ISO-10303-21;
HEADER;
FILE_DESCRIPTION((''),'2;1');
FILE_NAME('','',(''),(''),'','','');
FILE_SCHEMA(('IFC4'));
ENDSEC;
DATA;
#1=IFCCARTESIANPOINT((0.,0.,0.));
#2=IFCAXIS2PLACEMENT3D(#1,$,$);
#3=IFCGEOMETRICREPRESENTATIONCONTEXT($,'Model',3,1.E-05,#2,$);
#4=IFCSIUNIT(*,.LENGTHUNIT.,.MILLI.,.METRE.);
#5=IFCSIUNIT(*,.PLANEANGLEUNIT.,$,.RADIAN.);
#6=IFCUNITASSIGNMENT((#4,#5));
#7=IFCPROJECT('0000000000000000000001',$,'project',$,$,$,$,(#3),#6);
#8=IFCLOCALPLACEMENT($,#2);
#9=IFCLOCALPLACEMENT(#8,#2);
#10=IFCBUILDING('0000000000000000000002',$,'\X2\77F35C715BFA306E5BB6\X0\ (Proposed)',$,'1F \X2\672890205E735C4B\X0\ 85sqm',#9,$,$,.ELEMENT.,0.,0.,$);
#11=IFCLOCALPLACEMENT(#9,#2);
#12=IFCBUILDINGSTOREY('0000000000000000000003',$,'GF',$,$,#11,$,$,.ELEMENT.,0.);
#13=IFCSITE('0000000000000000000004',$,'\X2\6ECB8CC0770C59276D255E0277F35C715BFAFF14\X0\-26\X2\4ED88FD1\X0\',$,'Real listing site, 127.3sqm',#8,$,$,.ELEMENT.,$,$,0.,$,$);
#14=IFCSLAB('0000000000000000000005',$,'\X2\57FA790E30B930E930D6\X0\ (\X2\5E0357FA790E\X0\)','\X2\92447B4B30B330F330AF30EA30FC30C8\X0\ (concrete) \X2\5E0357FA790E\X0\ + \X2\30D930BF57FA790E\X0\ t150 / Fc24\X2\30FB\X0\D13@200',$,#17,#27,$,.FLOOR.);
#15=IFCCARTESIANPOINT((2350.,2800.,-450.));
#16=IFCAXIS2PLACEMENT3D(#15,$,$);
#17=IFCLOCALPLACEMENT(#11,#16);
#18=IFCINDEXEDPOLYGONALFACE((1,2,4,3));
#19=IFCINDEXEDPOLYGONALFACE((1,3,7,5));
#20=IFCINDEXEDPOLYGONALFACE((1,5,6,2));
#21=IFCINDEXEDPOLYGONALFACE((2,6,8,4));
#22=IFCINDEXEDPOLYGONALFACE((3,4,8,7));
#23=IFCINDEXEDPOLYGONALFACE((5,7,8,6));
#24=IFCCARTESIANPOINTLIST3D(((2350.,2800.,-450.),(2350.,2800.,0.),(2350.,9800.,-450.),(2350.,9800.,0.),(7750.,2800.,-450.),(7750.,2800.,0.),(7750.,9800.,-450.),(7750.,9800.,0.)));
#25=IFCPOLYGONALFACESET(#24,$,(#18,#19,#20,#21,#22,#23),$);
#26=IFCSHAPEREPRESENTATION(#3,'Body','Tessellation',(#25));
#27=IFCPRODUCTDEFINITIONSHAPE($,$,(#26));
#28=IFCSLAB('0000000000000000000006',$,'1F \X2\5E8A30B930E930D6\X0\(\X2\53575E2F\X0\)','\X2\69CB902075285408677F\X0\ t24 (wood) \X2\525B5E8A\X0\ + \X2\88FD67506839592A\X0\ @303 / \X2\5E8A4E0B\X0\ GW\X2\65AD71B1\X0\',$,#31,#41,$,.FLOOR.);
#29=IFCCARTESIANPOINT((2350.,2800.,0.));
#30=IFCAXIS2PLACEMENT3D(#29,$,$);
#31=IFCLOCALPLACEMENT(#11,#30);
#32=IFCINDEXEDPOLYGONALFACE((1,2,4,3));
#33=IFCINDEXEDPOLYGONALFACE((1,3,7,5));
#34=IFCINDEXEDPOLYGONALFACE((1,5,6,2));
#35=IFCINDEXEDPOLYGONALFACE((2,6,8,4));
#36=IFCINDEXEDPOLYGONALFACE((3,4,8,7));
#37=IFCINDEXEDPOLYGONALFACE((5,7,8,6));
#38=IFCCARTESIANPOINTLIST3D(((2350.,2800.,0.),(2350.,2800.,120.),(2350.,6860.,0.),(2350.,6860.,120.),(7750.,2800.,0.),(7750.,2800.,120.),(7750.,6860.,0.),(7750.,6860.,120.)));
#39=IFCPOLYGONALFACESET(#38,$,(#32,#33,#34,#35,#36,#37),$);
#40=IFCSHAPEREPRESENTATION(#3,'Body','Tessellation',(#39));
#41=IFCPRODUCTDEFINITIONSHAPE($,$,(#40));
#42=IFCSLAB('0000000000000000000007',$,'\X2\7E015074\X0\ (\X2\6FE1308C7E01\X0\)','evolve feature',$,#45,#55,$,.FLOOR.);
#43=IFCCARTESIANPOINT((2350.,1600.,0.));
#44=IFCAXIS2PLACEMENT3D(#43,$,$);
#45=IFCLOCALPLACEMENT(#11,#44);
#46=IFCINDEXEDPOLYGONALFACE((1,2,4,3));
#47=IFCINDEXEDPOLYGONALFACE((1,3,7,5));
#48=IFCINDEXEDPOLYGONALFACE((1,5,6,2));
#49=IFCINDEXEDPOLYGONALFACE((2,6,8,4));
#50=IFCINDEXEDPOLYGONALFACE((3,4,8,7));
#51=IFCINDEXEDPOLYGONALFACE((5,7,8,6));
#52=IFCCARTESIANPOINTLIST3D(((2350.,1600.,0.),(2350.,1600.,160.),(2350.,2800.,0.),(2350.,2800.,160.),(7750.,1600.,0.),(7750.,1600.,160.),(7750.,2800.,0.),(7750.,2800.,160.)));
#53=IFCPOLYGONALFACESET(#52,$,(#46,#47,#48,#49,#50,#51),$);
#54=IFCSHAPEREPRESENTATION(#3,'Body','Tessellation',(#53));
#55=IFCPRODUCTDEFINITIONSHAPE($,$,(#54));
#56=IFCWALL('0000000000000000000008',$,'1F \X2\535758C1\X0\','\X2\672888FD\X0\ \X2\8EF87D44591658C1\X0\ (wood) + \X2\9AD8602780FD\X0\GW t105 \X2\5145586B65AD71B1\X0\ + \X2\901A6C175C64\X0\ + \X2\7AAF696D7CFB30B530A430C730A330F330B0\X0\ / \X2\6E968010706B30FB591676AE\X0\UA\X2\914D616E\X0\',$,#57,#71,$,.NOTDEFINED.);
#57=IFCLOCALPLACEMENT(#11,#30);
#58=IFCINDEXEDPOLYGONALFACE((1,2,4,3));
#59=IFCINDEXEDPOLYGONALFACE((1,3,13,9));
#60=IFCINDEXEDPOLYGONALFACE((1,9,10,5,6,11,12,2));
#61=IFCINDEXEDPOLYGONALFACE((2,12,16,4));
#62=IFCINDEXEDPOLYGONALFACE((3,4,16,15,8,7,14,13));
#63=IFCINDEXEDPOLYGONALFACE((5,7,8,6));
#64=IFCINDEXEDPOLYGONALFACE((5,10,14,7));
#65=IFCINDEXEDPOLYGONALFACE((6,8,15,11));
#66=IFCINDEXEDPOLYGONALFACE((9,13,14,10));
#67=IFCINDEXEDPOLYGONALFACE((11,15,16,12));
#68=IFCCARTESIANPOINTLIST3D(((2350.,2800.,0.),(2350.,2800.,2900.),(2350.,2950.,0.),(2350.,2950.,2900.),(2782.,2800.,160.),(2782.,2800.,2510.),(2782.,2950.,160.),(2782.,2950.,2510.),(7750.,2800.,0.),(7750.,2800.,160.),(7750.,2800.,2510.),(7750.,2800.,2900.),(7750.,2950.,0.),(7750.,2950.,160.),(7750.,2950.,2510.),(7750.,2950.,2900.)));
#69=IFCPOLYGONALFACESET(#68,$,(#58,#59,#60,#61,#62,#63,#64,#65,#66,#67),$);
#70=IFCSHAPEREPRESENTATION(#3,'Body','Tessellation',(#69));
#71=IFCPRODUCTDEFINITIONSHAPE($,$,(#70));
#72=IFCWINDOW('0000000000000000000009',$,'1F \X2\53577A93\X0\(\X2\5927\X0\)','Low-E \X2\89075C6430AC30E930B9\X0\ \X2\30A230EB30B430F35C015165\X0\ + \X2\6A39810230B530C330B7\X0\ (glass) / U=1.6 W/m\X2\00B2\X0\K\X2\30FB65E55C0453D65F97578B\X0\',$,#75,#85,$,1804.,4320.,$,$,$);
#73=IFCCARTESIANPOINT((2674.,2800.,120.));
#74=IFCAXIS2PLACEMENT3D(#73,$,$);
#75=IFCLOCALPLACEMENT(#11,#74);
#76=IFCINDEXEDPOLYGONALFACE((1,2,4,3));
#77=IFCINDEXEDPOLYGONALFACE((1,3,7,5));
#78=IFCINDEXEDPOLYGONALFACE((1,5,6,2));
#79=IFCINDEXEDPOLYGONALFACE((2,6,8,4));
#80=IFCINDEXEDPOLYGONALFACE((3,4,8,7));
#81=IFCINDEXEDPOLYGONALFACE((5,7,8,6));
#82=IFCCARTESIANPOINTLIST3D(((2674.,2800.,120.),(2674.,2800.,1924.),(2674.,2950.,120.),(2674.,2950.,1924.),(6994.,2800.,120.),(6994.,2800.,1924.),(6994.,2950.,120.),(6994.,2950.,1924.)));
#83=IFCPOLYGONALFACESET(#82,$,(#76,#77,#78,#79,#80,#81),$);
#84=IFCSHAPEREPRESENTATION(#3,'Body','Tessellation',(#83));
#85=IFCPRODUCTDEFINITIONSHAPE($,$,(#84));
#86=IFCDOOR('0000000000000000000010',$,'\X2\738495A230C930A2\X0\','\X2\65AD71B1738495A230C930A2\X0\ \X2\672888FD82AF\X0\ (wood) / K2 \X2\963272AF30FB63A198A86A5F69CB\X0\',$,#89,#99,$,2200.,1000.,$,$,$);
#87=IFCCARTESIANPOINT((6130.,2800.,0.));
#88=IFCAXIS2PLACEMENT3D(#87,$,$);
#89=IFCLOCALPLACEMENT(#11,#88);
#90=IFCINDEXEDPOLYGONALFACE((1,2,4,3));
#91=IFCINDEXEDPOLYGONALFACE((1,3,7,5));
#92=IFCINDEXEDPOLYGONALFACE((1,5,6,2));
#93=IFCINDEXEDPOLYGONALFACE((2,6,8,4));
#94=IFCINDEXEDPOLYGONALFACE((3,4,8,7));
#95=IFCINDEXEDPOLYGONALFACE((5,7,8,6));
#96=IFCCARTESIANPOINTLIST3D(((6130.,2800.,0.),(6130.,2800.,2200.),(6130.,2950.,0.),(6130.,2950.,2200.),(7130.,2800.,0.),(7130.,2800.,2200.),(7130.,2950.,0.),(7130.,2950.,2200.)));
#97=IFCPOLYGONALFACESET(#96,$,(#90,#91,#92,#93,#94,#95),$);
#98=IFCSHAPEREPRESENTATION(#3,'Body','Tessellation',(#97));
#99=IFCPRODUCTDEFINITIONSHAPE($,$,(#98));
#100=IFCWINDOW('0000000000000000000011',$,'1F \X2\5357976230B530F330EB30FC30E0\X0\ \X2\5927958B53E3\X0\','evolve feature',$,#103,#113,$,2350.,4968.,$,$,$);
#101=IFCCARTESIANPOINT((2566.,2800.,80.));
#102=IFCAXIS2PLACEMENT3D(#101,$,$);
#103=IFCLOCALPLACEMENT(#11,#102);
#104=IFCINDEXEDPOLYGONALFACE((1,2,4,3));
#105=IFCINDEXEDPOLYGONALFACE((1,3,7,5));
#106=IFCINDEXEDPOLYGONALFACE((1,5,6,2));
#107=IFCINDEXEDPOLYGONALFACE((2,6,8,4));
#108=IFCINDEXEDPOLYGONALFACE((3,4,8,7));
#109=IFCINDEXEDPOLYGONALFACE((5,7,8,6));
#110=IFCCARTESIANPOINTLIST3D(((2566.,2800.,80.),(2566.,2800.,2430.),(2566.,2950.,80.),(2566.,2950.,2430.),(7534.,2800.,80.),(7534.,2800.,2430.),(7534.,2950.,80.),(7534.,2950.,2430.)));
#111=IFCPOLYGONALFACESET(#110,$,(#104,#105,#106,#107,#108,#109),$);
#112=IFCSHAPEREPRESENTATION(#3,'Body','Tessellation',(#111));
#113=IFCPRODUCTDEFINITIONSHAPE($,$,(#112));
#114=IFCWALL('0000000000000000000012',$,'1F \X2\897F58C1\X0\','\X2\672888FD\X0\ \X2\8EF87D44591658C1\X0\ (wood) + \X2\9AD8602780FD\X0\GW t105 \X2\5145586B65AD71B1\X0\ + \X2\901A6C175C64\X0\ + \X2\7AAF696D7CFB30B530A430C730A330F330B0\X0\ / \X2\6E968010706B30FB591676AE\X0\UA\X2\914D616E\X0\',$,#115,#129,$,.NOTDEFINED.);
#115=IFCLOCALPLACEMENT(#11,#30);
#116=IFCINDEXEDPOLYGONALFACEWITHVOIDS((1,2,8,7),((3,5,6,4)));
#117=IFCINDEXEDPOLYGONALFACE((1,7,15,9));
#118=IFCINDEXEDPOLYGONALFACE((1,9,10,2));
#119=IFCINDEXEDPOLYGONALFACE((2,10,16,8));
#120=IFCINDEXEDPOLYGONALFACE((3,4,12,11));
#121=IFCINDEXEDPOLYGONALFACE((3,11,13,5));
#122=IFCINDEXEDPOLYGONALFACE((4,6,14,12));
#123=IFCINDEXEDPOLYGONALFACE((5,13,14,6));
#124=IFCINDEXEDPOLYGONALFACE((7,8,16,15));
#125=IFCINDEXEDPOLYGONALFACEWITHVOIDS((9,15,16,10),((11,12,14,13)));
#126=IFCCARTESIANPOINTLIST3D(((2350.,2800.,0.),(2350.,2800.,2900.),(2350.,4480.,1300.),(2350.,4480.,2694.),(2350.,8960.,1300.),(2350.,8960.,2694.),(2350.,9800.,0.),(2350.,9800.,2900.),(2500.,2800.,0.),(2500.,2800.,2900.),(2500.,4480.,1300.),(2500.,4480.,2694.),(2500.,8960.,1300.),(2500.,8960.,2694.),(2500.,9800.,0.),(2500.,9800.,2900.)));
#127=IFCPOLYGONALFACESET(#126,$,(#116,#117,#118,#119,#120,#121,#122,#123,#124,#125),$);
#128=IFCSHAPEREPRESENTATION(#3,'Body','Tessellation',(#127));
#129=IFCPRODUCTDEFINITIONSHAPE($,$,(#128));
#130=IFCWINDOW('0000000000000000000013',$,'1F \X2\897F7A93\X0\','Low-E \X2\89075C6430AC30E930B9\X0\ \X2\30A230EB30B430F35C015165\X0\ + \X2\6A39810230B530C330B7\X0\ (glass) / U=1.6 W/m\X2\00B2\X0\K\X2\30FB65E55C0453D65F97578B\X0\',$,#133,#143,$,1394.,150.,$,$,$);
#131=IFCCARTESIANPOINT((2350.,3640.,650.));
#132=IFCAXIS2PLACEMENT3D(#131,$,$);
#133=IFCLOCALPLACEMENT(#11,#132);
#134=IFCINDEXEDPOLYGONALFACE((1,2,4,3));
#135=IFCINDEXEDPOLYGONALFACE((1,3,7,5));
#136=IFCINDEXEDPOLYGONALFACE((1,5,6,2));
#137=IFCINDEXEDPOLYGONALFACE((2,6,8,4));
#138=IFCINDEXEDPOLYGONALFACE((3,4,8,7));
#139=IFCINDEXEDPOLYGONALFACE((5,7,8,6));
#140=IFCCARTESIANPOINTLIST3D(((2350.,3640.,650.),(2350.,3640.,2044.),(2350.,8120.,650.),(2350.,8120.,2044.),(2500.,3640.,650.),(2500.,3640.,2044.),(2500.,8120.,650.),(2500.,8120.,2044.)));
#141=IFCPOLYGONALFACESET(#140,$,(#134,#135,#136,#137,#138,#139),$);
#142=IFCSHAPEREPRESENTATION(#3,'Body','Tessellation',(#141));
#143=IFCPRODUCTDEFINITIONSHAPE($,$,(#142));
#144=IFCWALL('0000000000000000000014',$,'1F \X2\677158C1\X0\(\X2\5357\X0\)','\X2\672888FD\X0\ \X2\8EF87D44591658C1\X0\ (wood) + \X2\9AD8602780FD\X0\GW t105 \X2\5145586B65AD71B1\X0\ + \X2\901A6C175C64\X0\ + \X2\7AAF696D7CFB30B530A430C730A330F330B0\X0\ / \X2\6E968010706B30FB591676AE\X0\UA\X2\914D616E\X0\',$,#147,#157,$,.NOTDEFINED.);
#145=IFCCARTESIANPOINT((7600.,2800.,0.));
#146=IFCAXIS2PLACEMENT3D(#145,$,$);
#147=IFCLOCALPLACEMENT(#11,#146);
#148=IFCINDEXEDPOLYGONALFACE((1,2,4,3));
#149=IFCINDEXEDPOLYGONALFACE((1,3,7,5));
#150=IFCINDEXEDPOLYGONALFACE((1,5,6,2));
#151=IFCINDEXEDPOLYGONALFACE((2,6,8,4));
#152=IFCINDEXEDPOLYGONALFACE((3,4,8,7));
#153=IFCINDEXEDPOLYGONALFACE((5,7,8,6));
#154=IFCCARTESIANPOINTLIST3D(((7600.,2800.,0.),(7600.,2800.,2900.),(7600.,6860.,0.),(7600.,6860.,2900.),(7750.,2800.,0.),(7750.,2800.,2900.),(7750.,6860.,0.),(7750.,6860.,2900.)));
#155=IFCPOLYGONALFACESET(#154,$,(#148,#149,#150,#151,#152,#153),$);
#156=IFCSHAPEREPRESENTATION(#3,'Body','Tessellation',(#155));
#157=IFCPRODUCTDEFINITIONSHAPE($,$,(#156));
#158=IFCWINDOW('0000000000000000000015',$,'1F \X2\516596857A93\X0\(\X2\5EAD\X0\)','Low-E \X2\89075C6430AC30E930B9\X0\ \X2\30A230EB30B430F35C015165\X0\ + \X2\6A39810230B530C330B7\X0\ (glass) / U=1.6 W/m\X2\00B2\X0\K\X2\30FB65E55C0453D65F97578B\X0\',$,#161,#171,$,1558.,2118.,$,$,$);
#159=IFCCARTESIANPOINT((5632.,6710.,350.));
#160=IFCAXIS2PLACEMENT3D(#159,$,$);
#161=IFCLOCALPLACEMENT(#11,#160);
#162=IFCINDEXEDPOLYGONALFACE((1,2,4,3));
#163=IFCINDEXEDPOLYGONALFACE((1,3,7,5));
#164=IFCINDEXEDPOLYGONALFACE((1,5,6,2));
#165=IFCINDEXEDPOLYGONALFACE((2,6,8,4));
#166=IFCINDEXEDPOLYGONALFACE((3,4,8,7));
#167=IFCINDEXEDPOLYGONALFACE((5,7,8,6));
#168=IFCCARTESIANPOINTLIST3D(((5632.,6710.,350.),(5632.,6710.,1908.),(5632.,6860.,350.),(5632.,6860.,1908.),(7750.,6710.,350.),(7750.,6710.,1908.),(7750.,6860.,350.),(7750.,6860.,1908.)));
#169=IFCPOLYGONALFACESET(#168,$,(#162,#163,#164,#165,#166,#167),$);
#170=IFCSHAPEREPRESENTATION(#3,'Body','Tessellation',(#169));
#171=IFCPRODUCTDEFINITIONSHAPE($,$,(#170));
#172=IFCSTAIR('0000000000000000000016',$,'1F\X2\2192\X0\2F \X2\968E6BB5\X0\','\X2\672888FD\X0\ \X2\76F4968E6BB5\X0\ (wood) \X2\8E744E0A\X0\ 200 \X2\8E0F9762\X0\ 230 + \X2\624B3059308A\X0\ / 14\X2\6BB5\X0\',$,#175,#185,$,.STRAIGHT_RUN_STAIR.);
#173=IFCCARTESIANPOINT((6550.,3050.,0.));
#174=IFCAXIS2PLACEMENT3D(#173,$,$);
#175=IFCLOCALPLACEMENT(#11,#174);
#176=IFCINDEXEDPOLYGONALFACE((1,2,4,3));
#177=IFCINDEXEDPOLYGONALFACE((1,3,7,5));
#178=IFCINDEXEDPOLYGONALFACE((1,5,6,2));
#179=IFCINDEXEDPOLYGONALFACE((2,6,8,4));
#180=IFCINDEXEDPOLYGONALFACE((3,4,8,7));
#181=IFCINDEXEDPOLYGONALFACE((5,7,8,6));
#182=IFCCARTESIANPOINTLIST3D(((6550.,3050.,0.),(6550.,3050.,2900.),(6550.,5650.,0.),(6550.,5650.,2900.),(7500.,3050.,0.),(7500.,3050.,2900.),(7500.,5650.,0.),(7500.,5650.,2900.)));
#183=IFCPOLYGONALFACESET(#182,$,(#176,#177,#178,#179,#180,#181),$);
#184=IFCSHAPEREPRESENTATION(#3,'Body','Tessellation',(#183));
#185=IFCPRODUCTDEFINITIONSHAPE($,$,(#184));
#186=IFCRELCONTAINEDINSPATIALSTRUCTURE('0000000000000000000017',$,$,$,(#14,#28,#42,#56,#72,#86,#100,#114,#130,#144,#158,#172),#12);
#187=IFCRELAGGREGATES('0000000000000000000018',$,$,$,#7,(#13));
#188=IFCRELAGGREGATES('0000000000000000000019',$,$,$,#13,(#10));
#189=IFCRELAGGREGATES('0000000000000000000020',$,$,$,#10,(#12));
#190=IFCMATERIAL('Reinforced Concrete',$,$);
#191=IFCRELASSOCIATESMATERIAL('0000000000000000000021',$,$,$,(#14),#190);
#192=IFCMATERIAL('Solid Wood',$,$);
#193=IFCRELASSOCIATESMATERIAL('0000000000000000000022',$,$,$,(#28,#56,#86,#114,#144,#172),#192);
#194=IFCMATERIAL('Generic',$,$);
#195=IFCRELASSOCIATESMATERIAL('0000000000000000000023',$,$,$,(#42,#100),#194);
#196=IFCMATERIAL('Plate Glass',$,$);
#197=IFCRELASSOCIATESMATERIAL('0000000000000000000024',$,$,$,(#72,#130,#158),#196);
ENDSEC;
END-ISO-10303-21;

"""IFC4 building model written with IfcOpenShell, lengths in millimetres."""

from ifc_helpers import new_model, si_unit, frame, frame_2d, origin, place, context, project, spatial, rectangle, extrude, material, element, fill, save


model = new_model("IFC4")

# Units and contexts
model_context = context("Model", 3, precision=1e-05, world=origin())
ifc_project = project(units=[si_unit("LENGTHUNIT", "METRE", prefix="MILLI"), si_unit("PLANEANGLEUNIT", "RADIAN")], contexts=[model_context])

# Site, building, storey
site_placement = place(None, origin())
site = spatial("IfcSite", under=ifc_project, at=site_placement, Name="滋賀県大津市石山寺４-26付近", ObjectType="Real listing site, 127.3sqm", CompositionType="ELEMENT", RefElevation=0.0)
building_placement = place(site_placement, origin())
building = spatial("IfcBuilding", under=site, at=building_placement, Name="石山寺の家 (Proposed)", ObjectType="1F 木造平屋 85sqm", CompositionType="ELEMENT", ElevationOfRefHeight=0.0, ElevationOfTerrain=0.0)
storey_placement = place(building_placement, origin())
storey = spatial("IfcBuildingStorey", under=building, at=storey_placement, Name="GF", CompositionType="ELEMENT", Elevation=0.0)

# Slabs
ifc_material_1 = material(Name="Reinforced Concrete")
slab_1_placement = place(storey_placement, frame((2350.0, 2800.0, -450.0)))
element("IfcSlab", 1, at=slab_1_placement, inside=storey, material=ifc_material_1, Name="基礎スラブ (布基礎)", Description="鉄筋コンクリート (concrete) 布基礎 + ベタ基礎 t150 / Fc24・D13@200", PredefinedType="FLOOR", context=model_context, shape_type="SweptSolid", body=[
    extrude(rectangle(XDim=5400.0, YDim=7000.0, at=frame_2d((2700.0, 3500.0))), frame((2350.0, 2800.0, -450.0)), (0.0, 0.0, 1.0), 450.0),
])
ifc_material_2 = material(Name="Solid Wood")
slab_2_placement = place(storey_placement, frame((2350.0, 2800.0, 0.0)))
element("IfcSlab", 2, at=slab_2_placement, inside=storey, material=ifc_material_2, Name="1F 床スラブ(南帯)", Description="構造用合板 t24 (wood) 剛床 + 製材根太 @303 / 床下 GW断熱", PredefinedType="FLOOR", context=model_context, shape_type="SweptSolid", body=[
    extrude(rectangle(XDim=5400.0, YDim=4060.0, at=frame_2d((2700.0, 2030.0))), frame((2350.0, 2800.0, 0.0)), (0.0, 0.0, 1.0), 120.0),
])
ifc_material_3 = material(Name="Generic")
slab_3_placement = place(storey_placement, frame((2350.0, 1600.0, 0.0)))
element("IfcSlab", 3, at=slab_3_placement, inside=storey, material=ifc_material_3, Name="縁側 (濡れ縁)", Description="evolve feature", PredefinedType="FLOOR", context=model_context, shape_type="SweptSolid", body=[
    extrude(rectangle(XDim=5400.0, YDim=1200.0, at=frame_2d((2700.0, 600.0))), frame((2350.0, 1600.0, 0.0)), (0.0, 0.0, 1.0), 160.0),
])

# Wall, openings, windows, door
wall_1_placement = place(storey_placement, frame((2350.0, 2800.0, 0.0)))
wall_1 = element("IfcWall", 4, at=wall_1_placement, inside=storey, material=ifc_material_2, Name="1F 南壁", Description="木製 軸組外壁 (wood) + 高性能GW t105 充填断熱 + 通気層 + 窯業系サイディング / 準耐火・外皮UA配慮", PredefinedType="NOTDEFINED", context=model_context, shape_type="SweptSolid", body=[
    extrude(rectangle(XDim=5400.0, YDim=150.0, at=frame_2d((2700.0, 75.0))), frame((2350.0, 2800.0, 0.0)), (0.0, 0.0, 1.0), 2900.0),
])
opening_1_placement = place(storey_placement, frame((2674.0, 2800.0, 120.0)))
opening_1 = element("IfcOpeningElement", 5, at=opening_1_placement, cuts=wall_1, PredefinedType="NOTDEFINED", context=model_context, shape_type="SweptSolid", body=[
    extrude(rectangle(XDim=4320.0, YDim=150.0, at=frame_2d((2160.0, 75.0))), frame((2674.0, 2800.0, 120.0)), (0.0, 0.0, 1.0), 1804.0),
])
opening_2_placement = place(storey_placement, frame((6130.0, 2800.0, 0.0)))
opening_2 = element("IfcOpeningElement", 6, at=opening_2_placement, cuts=wall_1, PredefinedType="NOTDEFINED", context=model_context, shape_type="SweptSolid", body=[
    extrude(rectangle(XDim=1000.0, YDim=150.0, at=frame_2d((500.0, 75.0))), frame((6130.0, 2800.0, 0.0)), (0.0, 0.0, 1.0), 2200.0),
])
opening_3_placement = place(storey_placement, frame((2566.0, 2800.0, 80.0)))
opening_3 = element("IfcOpeningElement", 7, at=opening_3_placement, cuts=wall_1, PredefinedType="NOTDEFINED", context=model_context, shape_type="SweptSolid", body=[
    extrude(rectangle(XDim=4968.0, YDim=150.0, at=frame_2d((2484.0, 75.0))), frame((2566.0, 2800.0, 80.0)), (0.0, 0.0, 1.0), 2350.0),
])
ifc_material_4 = material(Name="Plate Glass")
window_1_placement = place(storey_placement, frame((2674.0, 2800.0, 120.0)))
window_1 = element("IfcWindow", 8, at=window_1_placement, inside=storey, material=ifc_material_4, Name="1F 南窓(大)", Description="Low-E 複層ガラス アルゴン封入 + 樹脂サッシ (glass) / U=1.6 W/m²K・日射取得型", OverallHeight=1804.0, OverallWidth=4320.0, context=model_context, shape_type="SweptSolid", body=[
    extrude(rectangle(XDim=4320.0, YDim=150.0, at=frame_2d((2160.0, 75.0))), frame((2674.0, 2800.0, 120.0)), (0.0, 0.0, 1.0), 1804.0),
])
fill(opening_1, window_1)
door_1_placement = place(storey_placement, frame((6130.0, 2800.0, 0.0)))
door_1 = element("IfcDoor", 9, at=door_1_placement, inside=storey, material=ifc_material_2, Name="玄関ドア", Description="断熱玄関ドア 木製芯 (wood) / K2 防犯・採風機構", OverallHeight=2200.0, OverallWidth=1000.0, context=model_context, shape_type="SweptSolid", body=[
    extrude(rectangle(XDim=1000.0, YDim=150.0, at=frame_2d((500.0, 75.0))), frame((6130.0, 2800.0, 0.0)), (0.0, 0.0, 1.0), 2200.0),
])
fill(opening_2, door_1)
window_2_placement = place(storey_placement, frame((2566.0, 2800.0, 80.0)))
window_2 = element("IfcWindow", 10, at=window_2_placement, inside=storey, material=ifc_material_3, Name="1F 南面サンルーム 大開口", Description="evolve feature", OverallHeight=2350.0, OverallWidth=4968.0, context=model_context, shape_type="SweptSolid", body=[
    extrude(rectangle(XDim=4968.0, YDim=150.0, at=frame_2d((2484.0, 75.0))), frame((2566.0, 2800.0, 80.0)), (0.0, 0.0, 1.0), 2350.0),
])
fill(opening_3, window_2)

# Walls, openings, windows
wall_2_placement = place(storey_placement, frame((2350.0, 2800.0, 0.0)))
wall_2 = element("IfcWall", 11, at=wall_2_placement, inside=storey, material=ifc_material_2, Name="1F 西壁", Description="木製 軸組外壁 (wood) + 高性能GW t105 充填断熱 + 通気層 + 窯業系サイディング / 準耐火・外皮UA配慮", PredefinedType="NOTDEFINED", context=model_context, shape_type="SweptSolid", body=[
    extrude(rectangle(XDim=150.0, YDim=7000.0, at=frame_2d((75.0, 3500.0))), frame((2350.0, 2800.0, 0.0)), (0.0, 0.0, 1.0), 2900.0),
])
opening_4_placement = place(storey_placement, frame((2350.0, 3640.0, 650.0)))
opening_4 = element("IfcOpeningElement", 12, at=opening_4_placement, cuts=wall_2, PredefinedType="NOTDEFINED", context=model_context, shape_type="SweptSolid", body=[
    extrude(rectangle(XDim=150.0, YDim=4480.0, at=frame_2d((75.0, 2240.0))), frame((2350.0, 3640.0, 650.0)), (0.0, 0.0, 1.0), 1394.0),
])
window_3_placement = place(storey_placement, frame((2350.0, 3640.0, 650.0)))
window_3 = element("IfcWindow", 13, at=window_3_placement, inside=storey, material=ifc_material_4, Name="1F 西窓", Description="Low-E 複層ガラス アルゴン封入 + 樹脂サッシ (glass) / U=1.6 W/m²K・日射取得型", OverallHeight=1394.0, OverallWidth=150.0, context=model_context, shape_type="SweptSolid", body=[
    extrude(rectangle(XDim=150.0, YDim=4480.0, at=frame_2d((75.0, 2240.0))), frame((2350.0, 3640.0, 650.0)), (0.0, 0.0, 1.0), 1394.0),
])
fill(opening_4, window_3)
wall_3_placement = place(storey_placement, frame((7600.0, 2800.0, 0.0)))
wall_3 = element("IfcWall", 14, at=wall_3_placement, inside=storey, material=ifc_material_2, Name="1F 東壁(南)", Description="木製 軸組外壁 (wood) + 高性能GW t105 充填断熱 + 通気層 + 窯業系サイディング / 準耐火・外皮UA配慮", PredefinedType="NOTDEFINED", context=model_context, shape_type="SweptSolid", body=[
    extrude(rectangle(XDim=150.0, YDim=4060.0, at=frame_2d((75.0, 2030.0))), frame((7600.0, 2800.0, 0.0)), (0.0, 0.0, 1.0), 2900.0),
])
opening_5_placement = place(storey_placement, frame((5632.0, 6710.0, 350.0)))
opening_5 = element("IfcOpeningElement", 15, at=opening_5_placement, cuts=wall_3, PredefinedType="NOTDEFINED", context=model_context, shape_type="SweptSolid", body=[
    extrude(rectangle(XDim=2118.0, YDim=150.0, at=frame_2d((1059.0, 75.0))), frame((5632.0, 6710.0, 350.0)), (0.0, 0.0, 1.0), 1558.0),
])
window_4_placement = place(storey_placement, frame((5632.0, 6710.0, 350.0)))
window_4 = element("IfcWindow", 16, at=window_4_placement, inside=storey, material=ifc_material_4, Name="1F 入隅窓(庭)", Description="Low-E 複層ガラス アルゴン封入 + 樹脂サッシ (glass) / U=1.6 W/m²K・日射取得型", OverallHeight=1558.0, OverallWidth=2118.0, context=model_context, shape_type="SweptSolid", body=[
    extrude(rectangle(XDim=2118.0, YDim=150.0, at=frame_2d((1059.0, 75.0))), frame((5632.0, 6710.0, 350.0)), (0.0, 0.0, 1.0), 1558.0),
])
fill(opening_5, window_4)

# Stair
stair_placement = place(storey_placement, frame((6550.0, 3050.0, 0.0)))
element("IfcStair", 17, at=stair_placement, inside=storey, material=ifc_material_2, Name="1F→2F 階段", Description="木製 直階段 (wood) 蹴上 200 踏面 230 + 手すり / 14段", PredefinedType="STRAIGHT_RUN_STAIR", context=model_context, shape_type="SweptSolid", body=[
    extrude(rectangle(XDim=950.0, YDim=2600.0, at=frame_2d((475.0, 1300.0))), frame((6550.0, 3050.0, 0.0)), (0.0, 0.0, 1.0), 2900.0),
])

save(model, "model.ifc")
